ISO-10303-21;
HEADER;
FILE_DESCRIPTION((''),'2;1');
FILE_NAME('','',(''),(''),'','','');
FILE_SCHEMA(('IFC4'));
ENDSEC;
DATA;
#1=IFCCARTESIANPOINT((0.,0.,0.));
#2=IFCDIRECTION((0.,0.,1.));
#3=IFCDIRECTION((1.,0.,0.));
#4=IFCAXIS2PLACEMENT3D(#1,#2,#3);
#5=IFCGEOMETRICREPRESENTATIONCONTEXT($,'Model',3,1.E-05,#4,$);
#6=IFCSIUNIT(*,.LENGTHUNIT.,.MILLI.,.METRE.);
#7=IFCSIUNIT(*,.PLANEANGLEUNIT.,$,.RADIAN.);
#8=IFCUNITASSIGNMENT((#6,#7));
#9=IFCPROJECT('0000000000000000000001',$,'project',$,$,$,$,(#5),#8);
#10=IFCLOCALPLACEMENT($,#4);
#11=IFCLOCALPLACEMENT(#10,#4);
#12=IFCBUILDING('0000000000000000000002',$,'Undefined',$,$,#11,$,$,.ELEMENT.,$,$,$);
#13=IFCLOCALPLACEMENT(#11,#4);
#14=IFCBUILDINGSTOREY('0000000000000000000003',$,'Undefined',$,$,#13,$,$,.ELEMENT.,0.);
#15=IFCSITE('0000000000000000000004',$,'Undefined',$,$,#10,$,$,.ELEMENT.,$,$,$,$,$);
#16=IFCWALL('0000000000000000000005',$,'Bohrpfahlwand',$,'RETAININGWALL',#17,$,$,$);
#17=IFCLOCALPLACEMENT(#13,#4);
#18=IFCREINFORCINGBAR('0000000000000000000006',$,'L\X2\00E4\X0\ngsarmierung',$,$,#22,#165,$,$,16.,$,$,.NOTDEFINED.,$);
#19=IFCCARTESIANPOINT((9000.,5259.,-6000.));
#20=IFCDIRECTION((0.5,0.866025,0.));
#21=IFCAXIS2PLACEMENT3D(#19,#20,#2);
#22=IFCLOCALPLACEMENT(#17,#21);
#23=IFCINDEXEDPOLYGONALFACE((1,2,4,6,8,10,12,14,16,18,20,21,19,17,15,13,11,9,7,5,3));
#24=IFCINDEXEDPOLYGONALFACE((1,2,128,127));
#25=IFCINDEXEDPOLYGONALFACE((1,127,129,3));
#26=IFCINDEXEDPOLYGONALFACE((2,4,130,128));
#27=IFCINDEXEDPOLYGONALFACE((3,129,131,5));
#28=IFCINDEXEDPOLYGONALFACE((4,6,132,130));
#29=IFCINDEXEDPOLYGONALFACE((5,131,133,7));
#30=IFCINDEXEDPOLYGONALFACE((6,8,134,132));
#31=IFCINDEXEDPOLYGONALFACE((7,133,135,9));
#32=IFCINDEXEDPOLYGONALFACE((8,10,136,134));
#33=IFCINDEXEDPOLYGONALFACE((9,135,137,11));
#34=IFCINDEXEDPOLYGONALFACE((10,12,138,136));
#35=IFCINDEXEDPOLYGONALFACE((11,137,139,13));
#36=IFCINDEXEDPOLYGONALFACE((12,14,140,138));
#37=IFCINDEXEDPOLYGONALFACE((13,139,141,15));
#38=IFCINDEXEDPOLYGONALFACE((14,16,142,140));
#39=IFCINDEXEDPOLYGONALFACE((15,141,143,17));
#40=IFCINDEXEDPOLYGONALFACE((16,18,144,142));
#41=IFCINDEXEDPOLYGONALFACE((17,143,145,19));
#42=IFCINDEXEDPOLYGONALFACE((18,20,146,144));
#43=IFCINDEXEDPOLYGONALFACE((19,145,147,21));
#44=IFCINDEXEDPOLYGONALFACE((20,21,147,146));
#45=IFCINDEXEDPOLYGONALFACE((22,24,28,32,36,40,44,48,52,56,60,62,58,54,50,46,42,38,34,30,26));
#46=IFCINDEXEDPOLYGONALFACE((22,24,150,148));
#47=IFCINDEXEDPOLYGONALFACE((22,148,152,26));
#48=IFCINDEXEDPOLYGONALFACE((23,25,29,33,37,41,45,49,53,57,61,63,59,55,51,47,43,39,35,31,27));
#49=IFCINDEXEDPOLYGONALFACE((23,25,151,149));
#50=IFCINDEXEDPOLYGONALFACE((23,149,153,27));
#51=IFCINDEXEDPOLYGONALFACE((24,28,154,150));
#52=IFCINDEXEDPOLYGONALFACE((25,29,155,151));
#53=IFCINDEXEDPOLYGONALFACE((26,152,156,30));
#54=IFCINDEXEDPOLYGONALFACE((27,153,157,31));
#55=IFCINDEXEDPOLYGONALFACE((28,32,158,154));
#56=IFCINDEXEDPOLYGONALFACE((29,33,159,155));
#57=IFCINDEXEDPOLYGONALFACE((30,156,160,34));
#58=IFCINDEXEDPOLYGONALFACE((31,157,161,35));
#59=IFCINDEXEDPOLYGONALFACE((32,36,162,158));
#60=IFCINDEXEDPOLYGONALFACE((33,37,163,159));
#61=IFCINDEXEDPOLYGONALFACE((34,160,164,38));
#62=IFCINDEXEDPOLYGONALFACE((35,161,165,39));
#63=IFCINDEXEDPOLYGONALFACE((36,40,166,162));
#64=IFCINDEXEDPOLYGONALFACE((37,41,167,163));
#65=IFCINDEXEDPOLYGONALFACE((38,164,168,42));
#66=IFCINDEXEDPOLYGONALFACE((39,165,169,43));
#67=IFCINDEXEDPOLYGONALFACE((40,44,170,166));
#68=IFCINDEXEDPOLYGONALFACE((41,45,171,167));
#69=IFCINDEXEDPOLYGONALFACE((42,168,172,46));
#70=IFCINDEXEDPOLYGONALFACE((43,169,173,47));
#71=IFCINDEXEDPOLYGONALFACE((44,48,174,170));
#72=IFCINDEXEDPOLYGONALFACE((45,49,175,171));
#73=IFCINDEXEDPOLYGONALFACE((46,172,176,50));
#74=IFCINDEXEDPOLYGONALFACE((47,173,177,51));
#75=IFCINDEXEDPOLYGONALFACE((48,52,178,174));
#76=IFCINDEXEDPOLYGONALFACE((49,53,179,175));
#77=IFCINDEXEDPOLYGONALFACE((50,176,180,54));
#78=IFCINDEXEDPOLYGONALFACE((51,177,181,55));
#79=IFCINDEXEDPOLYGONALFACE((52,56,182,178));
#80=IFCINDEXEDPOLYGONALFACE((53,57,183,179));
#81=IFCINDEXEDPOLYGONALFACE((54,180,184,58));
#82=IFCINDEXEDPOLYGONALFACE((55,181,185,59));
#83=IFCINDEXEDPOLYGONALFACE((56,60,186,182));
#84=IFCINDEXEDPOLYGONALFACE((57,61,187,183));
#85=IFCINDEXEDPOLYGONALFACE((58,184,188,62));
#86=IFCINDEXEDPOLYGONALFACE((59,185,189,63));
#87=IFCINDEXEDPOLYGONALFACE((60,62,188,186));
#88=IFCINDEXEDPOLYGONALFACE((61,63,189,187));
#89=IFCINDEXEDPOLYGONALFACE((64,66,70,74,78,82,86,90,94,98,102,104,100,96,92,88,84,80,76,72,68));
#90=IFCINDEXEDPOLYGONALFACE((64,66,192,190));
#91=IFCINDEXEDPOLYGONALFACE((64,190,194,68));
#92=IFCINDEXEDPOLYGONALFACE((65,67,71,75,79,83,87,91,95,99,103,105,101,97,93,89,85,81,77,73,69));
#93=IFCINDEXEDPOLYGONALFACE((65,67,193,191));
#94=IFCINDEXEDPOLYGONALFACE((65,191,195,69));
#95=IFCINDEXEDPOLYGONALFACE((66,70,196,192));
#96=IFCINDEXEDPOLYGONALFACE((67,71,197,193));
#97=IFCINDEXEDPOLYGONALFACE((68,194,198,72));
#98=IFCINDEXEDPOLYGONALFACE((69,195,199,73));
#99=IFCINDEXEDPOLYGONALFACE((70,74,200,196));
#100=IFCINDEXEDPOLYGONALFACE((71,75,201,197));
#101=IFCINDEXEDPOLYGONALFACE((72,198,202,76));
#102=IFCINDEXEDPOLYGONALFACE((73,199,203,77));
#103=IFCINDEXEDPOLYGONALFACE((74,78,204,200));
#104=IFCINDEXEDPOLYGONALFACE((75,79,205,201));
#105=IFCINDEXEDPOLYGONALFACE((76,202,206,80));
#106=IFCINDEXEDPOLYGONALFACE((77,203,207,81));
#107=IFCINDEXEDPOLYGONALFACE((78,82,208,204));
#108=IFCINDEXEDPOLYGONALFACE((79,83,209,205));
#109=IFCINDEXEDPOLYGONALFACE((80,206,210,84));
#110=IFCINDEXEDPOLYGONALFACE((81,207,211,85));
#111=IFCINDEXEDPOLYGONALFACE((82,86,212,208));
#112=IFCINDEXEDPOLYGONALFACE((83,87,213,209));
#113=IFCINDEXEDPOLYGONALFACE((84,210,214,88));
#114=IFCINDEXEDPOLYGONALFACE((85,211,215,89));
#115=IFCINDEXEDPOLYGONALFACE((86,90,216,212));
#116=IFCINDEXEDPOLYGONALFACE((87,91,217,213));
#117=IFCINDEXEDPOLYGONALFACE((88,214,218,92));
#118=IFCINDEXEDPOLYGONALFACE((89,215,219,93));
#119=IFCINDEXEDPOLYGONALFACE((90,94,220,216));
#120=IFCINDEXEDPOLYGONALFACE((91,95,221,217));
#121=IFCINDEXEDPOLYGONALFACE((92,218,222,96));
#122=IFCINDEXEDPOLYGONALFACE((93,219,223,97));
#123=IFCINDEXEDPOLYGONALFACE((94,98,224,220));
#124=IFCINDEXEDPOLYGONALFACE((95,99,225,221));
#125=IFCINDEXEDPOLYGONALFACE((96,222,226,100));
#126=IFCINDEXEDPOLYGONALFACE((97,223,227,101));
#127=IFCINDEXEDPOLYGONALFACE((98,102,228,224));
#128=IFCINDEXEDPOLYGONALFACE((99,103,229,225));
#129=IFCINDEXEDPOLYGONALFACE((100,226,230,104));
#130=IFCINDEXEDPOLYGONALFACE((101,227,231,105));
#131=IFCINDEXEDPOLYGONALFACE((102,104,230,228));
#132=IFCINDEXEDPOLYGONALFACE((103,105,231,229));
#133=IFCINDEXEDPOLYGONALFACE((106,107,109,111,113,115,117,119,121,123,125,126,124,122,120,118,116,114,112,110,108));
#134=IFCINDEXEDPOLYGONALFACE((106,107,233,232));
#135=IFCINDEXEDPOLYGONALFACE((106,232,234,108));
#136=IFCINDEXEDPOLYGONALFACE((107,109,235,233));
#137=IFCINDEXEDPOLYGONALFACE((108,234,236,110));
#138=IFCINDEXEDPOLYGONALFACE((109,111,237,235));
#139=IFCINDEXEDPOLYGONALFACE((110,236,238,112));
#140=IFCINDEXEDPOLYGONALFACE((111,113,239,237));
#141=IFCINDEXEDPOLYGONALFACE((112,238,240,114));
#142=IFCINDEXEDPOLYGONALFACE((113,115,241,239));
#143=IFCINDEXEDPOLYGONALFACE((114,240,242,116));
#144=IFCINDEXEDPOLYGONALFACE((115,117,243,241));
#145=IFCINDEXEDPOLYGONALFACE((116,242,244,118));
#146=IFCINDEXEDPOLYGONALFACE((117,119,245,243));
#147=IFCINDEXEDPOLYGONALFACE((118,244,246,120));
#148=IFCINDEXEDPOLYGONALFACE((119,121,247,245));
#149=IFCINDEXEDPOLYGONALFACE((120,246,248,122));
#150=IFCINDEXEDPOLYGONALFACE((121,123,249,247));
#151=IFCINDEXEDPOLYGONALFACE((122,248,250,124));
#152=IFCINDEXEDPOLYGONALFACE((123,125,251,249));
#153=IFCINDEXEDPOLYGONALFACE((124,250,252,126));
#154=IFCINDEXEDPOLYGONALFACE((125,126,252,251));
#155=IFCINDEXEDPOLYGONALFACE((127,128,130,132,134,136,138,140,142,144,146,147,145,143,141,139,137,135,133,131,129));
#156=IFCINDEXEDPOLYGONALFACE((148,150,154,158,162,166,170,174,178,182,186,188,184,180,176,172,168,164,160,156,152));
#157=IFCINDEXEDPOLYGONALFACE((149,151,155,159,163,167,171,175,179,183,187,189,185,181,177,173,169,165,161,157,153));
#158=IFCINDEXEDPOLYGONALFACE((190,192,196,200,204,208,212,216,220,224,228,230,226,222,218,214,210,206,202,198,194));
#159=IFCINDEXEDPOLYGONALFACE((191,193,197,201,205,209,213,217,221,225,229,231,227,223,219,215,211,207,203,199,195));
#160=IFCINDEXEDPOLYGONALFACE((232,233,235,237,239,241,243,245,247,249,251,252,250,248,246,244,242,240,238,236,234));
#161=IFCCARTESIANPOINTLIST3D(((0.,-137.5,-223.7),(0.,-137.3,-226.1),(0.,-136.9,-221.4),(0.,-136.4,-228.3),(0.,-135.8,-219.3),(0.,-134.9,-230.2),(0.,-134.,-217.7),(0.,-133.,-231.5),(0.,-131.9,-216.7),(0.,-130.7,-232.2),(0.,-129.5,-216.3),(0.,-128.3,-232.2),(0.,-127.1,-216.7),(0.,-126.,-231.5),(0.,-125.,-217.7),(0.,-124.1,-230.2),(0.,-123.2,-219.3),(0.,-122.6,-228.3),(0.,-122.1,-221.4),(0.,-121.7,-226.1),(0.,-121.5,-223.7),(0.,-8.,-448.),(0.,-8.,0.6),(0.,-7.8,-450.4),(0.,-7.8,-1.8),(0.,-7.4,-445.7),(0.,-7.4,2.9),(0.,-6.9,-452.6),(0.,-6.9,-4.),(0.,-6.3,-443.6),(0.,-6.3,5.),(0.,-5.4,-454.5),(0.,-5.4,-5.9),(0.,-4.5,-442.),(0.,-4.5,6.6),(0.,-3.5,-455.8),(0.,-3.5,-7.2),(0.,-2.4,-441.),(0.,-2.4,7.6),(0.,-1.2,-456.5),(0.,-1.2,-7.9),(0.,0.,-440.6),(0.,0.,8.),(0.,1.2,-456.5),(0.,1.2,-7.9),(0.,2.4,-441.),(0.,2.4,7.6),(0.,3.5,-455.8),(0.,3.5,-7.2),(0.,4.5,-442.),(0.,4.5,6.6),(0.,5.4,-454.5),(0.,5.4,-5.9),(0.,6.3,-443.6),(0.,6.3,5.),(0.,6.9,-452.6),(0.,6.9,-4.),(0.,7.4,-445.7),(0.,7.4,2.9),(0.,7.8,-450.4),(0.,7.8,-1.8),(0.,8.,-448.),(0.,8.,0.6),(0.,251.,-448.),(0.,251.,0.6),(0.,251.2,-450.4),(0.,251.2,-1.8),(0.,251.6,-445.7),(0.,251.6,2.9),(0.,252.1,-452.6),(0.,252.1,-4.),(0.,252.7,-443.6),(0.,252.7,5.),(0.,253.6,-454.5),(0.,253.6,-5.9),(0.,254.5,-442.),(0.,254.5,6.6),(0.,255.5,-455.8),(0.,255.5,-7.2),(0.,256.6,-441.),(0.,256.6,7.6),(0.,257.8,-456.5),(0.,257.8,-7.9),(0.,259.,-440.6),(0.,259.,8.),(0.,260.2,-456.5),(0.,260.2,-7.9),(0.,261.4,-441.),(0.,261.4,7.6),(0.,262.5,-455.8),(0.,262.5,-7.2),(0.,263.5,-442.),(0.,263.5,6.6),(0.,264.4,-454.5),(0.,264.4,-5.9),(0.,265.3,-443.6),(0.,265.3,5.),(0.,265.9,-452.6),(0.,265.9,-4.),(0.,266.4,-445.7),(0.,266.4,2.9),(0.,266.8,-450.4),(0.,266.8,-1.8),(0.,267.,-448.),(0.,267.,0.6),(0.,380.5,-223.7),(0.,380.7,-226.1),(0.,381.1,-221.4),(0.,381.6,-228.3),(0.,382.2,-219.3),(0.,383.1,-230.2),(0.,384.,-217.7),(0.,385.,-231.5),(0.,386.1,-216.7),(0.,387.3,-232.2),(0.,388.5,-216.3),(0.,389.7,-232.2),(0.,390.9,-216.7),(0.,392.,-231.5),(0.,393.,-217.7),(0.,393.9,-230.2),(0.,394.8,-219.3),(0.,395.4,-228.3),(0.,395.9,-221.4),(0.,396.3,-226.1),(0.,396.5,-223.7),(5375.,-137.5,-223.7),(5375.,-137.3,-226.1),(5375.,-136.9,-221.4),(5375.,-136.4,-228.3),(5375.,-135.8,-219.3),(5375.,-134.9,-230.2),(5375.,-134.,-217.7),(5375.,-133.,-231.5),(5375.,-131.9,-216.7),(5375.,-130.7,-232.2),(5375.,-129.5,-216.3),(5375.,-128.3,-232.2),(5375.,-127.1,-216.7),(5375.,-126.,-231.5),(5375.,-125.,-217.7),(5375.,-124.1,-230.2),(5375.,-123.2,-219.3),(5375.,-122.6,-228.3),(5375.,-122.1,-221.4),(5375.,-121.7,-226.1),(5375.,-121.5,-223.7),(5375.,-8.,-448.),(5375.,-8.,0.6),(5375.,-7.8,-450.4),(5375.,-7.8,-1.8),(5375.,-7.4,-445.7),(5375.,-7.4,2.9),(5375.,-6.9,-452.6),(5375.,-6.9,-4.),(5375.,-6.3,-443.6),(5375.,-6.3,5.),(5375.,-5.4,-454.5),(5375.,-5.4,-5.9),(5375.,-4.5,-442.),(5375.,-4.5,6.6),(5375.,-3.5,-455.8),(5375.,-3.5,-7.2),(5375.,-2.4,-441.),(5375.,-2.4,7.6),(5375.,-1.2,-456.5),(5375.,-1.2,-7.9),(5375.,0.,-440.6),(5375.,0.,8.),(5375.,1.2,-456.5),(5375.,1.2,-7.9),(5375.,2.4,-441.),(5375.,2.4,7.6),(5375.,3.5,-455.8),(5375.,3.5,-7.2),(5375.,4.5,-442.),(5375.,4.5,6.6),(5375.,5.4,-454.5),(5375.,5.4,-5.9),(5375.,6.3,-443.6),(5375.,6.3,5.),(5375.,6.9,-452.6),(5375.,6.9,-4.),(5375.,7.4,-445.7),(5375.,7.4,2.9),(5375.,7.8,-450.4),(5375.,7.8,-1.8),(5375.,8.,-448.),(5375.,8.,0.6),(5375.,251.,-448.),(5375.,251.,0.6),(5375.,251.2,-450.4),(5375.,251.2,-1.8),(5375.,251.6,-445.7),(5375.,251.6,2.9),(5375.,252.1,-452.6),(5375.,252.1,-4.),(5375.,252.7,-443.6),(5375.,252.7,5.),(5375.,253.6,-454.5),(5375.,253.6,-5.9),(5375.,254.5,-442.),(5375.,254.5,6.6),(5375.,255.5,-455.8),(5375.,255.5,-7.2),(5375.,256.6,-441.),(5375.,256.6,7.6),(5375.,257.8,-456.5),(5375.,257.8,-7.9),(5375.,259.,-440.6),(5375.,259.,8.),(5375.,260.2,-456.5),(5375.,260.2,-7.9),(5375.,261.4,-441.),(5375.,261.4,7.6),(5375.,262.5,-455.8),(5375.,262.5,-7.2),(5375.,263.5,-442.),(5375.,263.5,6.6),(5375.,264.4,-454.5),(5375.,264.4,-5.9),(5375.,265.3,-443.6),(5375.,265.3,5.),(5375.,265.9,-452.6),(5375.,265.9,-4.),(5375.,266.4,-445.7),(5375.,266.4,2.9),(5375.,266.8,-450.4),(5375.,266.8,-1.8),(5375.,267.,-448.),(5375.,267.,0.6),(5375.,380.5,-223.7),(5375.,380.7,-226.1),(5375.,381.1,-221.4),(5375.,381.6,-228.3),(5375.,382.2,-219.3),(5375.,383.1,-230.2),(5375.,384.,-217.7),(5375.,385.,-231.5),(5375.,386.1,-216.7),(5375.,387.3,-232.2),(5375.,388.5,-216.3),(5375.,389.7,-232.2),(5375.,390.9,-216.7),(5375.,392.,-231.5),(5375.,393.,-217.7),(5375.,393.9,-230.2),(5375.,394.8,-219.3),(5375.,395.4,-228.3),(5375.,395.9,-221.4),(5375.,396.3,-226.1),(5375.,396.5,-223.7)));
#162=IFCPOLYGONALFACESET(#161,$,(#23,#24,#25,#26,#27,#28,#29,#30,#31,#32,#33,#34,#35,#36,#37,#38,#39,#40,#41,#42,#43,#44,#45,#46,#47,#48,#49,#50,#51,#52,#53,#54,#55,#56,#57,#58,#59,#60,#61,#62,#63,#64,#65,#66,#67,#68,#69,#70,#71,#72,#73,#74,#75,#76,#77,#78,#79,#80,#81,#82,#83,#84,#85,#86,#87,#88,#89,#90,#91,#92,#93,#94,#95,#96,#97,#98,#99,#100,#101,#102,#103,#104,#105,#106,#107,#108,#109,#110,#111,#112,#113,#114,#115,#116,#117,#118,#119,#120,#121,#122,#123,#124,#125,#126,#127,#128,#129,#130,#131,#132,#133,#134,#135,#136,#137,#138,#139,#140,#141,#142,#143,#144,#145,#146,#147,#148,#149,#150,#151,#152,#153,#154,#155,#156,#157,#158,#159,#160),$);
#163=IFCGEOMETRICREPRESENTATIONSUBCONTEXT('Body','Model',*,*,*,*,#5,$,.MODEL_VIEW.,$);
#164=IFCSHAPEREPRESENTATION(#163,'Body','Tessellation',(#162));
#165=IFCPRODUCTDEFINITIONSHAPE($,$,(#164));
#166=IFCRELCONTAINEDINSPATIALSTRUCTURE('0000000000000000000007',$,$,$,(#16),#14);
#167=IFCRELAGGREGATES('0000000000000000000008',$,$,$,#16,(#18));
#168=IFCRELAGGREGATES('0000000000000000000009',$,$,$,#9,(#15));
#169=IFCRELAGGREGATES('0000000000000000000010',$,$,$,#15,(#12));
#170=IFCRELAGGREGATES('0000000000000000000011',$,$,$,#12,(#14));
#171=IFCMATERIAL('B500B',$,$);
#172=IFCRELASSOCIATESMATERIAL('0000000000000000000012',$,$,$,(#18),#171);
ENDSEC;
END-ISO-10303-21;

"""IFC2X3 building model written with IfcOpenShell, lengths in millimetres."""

from ifc_helpers import new_model, entity, si_unit, frame, origin_with_axes, place, context, subcontext, project, spatial, source, transform, mapped, material, element, aggregate, save


model = new_model("IFC2X3")

# Units and contexts
model_context = context("Model", 3, precision=1e-05, world=origin_with_axes())
body_context = subcontext(model_context, "Body", "Model", "MODEL_VIEW")
ifc_project = project(units=[si_unit("LENGTHUNIT", "METRE", prefix="MILLI"), si_unit("PLANEANGLEUNIT", "RADIAN")], contexts=[model_context])

# Site, building, storey
site_placement = place(None, origin_with_axes())
site = spatial("IfcSite", under=ifc_project, at=site_placement, Name="Undefined", CompositionType="ELEMENT")
building_placement = place(site_placement, origin_with_axes())
building = spatial("IfcBuilding", under=site, at=building_placement, Name="Undefined", CompositionType="ELEMENT")
storey_placement = place(building_placement, origin_with_axes())
storey = spatial("IfcBuildingStorey", under=building, at=storey_placement, Name="Undefined", CompositionType="ELEMENT", Elevation=0.0)

# Wall
wall_1_placement = place(storey_placement, origin_with_axes())
wall_1 = element("IfcWall", 1, at=wall_1_placement, inside=storey, Name="Bohrpfahlwand", ObjectType="RETAININGWALL")

# Shared definitions
ifc_material_1 = material(Name="B500B")

# Reinforcing bar
shared_shape_1 = source(origin_with_axes(), body_context, "Body", "AdvancedSweptSolid", [
    entity("IfcSweptDiskSolid", entity("IfcTrimmedCurve", entity("IfcLine", entity("IfcCartesianPoint", [0.0, 0.0, 0.0]), entity("IfcVector", entity("IfcDirection", [1.0, 0.0, 0.0]), 1.0)), [entity("IfcParameterValue", 0.0)], [entity("IfcParameterValue", 5375.0)], True, "PARAMETER"), 8.0, None, 0.0, 5375.0),
])
shared_shape_2 = source(origin_with_axes(), body_context, "Body", "AdvancedSweptSolid", [
    entity("IfcSweptDiskSolid", entity("IfcTrimmedCurve", entity("IfcLine", entity("IfcCartesianPoint", [0.0, 0.0, 0.0]), entity("IfcVector", entity("IfcDirection", [1.0, 0.0, 0.0]), 1.0)), [entity("IfcParameterValue", 0.0)], [entity("IfcParameterValue", 5375.0)], True, "PARAMETER"), 8.0, None, 0.0, 5375.0),
])
shared_shape_3 = source(origin_with_axes(), body_context, "Body", "AdvancedSweptSolid", [
    entity("IfcSweptDiskSolid", entity("IfcTrimmedCurve", entity("IfcLine", entity("IfcCartesianPoint", [0.0, 0.0, 0.0]), entity("IfcVector", entity("IfcDirection", [1.0, 0.0, 0.0]), 1.0)), [entity("IfcParameterValue", 0.0)], [entity("IfcParameterValue", 5375.0)], True, "PARAMETER"), 8.0, None, 0.0, 5375.0),
])
shared_shape_4 = source(origin_with_axes(), body_context, "Body", "AdvancedSweptSolid", [
    entity("IfcSweptDiskSolid", entity("IfcTrimmedCurve", entity("IfcLine", entity("IfcCartesianPoint", [0.0, 0.0, 0.0]), entity("IfcVector", entity("IfcDirection", [1.0, 0.0, 0.0]), 1.0)), [entity("IfcParameterValue", 0.0)], [entity("IfcParameterValue", 5375.0)], True, "PARAMETER"), 8.0, None, 0.0, 5375.0),
])
shared_shape_5 = source(origin_with_axes(), body_context, "Body", "AdvancedSweptSolid", [
    entity("IfcSweptDiskSolid", entity("IfcTrimmedCurve", entity("IfcLine", entity("IfcCartesianPoint", [0.0, 0.0, 0.0]), entity("IfcVector", entity("IfcDirection", [1.0, 0.0, 0.0]), 1.0)), [entity("IfcParameterValue", 0.0)], [entity("IfcParameterValue", 5375.0)], True, "PARAMETER"), 8.0, None, 0.0, 5375.0),
])
shared_shape_6 = source(origin_with_axes(), body_context, "Body", "AdvancedSweptSolid", [
    entity("IfcSweptDiskSolid", entity("IfcTrimmedCurve", entity("IfcLine", entity("IfcCartesianPoint", [0.0, 0.0, 0.0]), entity("IfcVector", entity("IfcDirection", [1.0, 0.0, 0.0]), 1.0)), [entity("IfcParameterValue", 0.0)], [entity("IfcParameterValue", 5375.0)], True, "PARAMETER"), 8.0, None, 0.0, 5375.0),
])
reinforcing_bar_1_placement = place(wall_1_placement, frame((9000.0, 5259.0, -6000.0), z_axis=(0.5, 0.866025, 0.0), x_axis=(0.0, 0.0, 1.0)))
reinforcing_bar_1 = element("IfcReinforcingBar", 2, at=reinforcing_bar_1_placement, material=ifc_material_1, Name="Längsarmierung", BarRole="NOTDEFINED", NominalDiameter=16.0, context=body_context, shape_type="MappedRepresentation", body=[
    mapped(shared_shape_1, transform((0.0, 0.0, 0.0))),
    mapped(shared_shape_2, transform((0.0, -129.5, -224.3))),
    mapped(shared_shape_3, transform((0.0, 0.0, -448.6))),
    mapped(shared_shape_4, transform((0.0, 259.0, -448.6))),
    mapped(shared_shape_5, transform((0.0, 388.5, -224.3))),
    mapped(shared_shape_6, transform((0.0, 259.0, 0.0))),
])
aggregate(wall_1, [reinforcing_bar_1])

save(model, "model.ifc")
